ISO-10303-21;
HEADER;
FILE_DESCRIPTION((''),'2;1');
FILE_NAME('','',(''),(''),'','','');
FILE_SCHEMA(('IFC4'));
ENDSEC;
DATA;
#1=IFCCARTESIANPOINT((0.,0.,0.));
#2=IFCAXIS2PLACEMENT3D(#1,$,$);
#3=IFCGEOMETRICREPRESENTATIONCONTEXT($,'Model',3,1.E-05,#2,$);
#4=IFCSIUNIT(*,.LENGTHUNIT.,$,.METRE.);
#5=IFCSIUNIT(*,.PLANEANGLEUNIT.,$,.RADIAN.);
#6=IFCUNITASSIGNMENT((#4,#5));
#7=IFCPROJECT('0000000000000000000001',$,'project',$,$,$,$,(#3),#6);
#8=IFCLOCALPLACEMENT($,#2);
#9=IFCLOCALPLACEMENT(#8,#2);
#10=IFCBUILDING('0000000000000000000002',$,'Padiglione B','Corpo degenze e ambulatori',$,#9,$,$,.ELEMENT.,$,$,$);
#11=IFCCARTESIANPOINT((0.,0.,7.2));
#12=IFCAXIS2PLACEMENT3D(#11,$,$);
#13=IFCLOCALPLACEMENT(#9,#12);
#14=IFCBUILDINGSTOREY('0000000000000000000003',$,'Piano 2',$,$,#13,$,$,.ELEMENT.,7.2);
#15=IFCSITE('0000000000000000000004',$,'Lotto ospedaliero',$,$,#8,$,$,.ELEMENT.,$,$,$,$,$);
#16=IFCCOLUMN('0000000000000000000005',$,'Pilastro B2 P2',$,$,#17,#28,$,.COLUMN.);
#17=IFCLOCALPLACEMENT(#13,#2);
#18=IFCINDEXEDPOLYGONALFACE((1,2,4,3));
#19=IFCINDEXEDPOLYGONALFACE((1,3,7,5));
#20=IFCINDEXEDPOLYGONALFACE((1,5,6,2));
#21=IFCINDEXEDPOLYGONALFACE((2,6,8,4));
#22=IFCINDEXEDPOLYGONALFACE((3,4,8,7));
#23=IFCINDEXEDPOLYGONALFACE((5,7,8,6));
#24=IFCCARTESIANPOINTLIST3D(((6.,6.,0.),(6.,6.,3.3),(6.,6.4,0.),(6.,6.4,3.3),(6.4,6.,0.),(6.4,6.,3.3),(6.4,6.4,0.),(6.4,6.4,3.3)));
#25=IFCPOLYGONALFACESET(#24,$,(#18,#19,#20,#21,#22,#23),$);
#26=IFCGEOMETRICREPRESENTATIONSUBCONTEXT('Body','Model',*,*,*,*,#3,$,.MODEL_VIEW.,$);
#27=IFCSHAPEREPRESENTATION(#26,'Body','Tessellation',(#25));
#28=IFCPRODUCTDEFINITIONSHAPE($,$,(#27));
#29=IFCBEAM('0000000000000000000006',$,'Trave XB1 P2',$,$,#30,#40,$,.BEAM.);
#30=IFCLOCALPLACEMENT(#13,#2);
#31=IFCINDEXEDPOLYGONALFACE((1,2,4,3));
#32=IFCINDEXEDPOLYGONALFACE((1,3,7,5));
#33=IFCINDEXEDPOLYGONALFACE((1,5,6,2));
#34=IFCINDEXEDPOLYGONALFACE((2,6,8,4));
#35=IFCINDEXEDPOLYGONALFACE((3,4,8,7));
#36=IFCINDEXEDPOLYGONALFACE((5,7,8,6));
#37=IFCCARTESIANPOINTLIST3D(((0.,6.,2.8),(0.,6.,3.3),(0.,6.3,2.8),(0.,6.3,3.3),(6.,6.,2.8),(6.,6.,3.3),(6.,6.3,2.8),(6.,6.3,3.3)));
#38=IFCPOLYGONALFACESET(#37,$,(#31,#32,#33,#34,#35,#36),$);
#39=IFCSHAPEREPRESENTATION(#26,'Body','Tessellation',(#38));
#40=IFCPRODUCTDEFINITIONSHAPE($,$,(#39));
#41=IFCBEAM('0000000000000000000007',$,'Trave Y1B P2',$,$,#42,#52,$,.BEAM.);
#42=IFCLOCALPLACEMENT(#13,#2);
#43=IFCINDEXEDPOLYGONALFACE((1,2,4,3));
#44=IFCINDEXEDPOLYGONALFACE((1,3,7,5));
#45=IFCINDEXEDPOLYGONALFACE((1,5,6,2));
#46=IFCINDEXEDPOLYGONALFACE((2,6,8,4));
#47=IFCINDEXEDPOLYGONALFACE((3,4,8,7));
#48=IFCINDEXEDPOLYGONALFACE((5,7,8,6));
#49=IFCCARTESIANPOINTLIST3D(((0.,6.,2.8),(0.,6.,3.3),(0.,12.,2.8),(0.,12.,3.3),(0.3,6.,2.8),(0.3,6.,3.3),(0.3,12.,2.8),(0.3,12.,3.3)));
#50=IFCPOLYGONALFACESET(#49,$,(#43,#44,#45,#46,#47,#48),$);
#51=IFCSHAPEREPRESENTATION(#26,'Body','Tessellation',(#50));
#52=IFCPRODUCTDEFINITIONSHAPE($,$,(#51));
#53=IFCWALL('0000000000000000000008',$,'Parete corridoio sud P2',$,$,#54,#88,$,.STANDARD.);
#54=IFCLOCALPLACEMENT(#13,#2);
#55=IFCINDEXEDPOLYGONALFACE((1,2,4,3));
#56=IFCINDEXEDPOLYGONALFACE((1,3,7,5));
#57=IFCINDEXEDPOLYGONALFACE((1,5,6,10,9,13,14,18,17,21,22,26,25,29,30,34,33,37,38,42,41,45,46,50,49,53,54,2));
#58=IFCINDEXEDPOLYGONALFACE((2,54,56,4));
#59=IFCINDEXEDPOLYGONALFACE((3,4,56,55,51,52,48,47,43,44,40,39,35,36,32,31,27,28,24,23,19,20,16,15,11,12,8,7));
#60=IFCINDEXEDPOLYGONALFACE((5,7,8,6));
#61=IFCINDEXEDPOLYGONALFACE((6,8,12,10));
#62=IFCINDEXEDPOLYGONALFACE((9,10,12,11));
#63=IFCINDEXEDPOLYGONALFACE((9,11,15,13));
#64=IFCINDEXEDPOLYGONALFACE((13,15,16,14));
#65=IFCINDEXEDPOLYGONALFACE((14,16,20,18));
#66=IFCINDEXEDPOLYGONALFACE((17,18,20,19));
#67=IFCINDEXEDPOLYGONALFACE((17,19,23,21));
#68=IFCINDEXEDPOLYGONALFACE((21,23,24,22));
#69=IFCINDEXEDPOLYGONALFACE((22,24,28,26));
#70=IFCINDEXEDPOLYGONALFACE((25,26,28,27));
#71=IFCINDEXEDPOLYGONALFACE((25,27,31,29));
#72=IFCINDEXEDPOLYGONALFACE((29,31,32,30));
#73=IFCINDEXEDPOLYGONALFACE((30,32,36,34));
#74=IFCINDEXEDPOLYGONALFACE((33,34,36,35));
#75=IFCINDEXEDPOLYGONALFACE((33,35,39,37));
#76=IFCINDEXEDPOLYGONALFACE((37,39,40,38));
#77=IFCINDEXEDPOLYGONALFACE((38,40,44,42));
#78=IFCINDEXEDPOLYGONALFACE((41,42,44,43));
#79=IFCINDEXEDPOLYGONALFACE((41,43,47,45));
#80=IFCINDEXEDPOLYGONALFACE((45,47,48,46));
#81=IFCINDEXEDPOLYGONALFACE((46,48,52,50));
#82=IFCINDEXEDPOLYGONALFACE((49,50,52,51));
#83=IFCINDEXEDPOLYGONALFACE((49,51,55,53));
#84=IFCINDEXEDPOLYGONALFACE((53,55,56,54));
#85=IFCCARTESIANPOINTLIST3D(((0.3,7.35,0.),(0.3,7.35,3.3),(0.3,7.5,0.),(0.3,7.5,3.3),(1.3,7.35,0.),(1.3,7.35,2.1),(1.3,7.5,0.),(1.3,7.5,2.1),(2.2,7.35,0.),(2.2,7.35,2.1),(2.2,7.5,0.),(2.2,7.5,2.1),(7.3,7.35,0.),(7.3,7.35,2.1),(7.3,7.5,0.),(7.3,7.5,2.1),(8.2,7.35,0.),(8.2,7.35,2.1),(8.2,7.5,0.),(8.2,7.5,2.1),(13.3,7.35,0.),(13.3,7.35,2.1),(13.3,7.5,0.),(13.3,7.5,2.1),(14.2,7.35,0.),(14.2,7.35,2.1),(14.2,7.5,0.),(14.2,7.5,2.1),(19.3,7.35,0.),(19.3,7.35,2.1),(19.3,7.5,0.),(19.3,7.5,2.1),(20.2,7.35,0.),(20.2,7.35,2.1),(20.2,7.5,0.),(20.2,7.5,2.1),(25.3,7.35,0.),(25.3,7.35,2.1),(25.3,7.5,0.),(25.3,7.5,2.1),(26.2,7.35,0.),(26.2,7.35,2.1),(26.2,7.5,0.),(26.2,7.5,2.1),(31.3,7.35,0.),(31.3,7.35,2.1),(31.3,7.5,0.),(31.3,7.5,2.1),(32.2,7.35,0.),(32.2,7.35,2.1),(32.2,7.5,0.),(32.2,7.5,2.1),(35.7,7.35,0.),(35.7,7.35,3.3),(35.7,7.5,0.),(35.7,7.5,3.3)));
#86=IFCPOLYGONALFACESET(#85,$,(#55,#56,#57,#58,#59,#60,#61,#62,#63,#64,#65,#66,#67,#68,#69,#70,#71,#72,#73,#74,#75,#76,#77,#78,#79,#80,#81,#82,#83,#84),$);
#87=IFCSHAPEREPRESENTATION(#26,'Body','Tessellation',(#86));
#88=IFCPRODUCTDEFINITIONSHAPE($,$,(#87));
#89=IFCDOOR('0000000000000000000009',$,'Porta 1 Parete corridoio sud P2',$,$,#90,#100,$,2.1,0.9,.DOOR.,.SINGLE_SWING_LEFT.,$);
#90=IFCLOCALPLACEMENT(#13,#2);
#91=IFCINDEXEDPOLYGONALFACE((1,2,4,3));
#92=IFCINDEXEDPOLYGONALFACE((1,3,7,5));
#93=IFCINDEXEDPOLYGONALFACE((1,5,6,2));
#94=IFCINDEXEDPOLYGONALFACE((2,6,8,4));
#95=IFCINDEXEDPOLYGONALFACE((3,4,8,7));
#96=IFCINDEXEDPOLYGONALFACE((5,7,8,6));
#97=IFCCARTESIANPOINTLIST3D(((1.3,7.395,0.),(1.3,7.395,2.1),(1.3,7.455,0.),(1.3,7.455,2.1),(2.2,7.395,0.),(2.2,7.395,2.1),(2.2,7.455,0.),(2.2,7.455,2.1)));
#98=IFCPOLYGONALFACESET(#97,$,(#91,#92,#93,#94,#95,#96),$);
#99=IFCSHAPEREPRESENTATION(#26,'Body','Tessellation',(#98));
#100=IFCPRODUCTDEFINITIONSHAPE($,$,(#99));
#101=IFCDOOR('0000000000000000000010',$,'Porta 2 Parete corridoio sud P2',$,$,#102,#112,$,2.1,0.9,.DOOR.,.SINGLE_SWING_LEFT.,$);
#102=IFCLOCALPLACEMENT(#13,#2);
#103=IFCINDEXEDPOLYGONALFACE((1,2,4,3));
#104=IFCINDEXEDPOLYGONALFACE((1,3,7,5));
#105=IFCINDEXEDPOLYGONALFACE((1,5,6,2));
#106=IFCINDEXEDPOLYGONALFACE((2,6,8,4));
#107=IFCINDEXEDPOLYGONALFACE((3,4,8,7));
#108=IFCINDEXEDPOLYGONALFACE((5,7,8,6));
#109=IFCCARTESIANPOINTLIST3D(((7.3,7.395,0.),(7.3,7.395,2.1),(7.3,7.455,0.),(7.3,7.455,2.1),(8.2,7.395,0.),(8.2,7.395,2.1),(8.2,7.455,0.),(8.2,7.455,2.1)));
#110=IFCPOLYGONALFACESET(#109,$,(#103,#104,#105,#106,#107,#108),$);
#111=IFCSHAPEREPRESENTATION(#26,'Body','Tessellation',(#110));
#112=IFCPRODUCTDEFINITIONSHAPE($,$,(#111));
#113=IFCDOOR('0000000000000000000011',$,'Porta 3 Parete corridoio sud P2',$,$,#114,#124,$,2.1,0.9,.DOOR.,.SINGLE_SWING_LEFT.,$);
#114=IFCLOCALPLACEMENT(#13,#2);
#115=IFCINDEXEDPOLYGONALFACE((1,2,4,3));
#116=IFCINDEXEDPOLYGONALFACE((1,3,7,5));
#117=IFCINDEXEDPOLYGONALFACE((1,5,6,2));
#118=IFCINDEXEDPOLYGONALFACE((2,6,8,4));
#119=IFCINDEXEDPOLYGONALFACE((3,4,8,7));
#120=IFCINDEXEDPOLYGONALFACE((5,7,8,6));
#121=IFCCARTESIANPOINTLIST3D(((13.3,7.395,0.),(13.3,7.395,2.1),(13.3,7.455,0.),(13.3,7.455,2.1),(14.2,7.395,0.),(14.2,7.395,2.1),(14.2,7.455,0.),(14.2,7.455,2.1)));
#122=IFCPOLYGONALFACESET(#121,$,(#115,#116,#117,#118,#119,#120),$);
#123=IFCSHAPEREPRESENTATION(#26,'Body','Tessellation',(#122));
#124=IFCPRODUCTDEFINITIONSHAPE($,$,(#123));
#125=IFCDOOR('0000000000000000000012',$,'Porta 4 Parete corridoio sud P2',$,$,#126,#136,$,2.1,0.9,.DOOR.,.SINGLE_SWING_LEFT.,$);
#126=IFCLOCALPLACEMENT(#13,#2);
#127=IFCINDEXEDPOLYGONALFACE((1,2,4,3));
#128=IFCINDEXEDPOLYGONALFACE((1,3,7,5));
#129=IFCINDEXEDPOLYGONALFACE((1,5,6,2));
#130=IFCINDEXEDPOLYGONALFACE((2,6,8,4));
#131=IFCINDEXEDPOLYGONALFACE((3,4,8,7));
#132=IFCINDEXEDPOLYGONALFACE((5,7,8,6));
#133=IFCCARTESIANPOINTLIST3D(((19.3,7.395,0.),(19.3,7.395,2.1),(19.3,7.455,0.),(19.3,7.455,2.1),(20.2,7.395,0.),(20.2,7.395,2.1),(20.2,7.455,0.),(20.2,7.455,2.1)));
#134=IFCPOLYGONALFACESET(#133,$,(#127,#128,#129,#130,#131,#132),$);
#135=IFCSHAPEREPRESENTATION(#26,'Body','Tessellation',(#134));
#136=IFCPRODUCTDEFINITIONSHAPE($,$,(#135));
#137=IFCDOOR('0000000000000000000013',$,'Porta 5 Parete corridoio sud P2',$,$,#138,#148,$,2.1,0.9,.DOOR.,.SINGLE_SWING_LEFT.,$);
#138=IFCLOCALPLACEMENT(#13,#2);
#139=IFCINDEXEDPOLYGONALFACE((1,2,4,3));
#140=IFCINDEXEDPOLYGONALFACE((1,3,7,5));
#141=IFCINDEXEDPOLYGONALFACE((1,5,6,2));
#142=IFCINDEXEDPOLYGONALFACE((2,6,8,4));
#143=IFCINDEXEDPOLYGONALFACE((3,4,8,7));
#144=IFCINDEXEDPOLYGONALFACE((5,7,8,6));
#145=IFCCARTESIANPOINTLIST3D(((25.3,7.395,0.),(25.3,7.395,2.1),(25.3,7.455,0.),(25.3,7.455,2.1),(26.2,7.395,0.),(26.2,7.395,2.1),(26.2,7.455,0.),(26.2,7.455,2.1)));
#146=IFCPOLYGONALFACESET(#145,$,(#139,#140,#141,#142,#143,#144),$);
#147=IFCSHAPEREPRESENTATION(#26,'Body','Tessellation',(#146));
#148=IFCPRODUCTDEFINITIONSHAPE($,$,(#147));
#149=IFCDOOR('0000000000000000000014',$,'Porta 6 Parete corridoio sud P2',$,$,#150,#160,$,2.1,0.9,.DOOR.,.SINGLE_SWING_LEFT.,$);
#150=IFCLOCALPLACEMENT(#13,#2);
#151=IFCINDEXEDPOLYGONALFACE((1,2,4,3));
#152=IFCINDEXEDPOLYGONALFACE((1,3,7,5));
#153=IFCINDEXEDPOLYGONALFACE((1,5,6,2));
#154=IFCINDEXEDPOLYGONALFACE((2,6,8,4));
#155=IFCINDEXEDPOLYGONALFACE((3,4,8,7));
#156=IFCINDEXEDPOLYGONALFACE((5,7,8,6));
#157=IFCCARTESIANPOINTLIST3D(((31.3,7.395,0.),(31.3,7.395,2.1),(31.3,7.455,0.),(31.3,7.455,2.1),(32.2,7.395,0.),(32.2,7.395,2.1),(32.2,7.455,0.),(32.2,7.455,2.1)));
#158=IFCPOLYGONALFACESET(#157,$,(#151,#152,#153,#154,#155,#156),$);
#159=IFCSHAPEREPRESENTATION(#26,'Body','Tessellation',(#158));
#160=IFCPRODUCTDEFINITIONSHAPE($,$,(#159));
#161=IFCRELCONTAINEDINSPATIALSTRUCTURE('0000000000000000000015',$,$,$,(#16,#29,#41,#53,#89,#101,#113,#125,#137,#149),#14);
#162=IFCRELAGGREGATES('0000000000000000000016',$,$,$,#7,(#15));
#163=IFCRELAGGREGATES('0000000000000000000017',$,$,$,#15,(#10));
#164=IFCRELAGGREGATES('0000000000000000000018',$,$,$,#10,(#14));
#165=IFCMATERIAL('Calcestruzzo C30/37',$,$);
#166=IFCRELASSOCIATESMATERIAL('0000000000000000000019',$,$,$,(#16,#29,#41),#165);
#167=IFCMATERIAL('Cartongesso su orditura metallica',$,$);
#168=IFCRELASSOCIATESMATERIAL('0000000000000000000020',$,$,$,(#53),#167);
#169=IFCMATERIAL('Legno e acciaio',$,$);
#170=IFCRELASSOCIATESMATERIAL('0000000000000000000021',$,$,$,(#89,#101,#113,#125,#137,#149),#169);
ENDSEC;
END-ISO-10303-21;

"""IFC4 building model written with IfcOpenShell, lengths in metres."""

from ifc_helpers import new_model, si_unit, frame, frame_2d, origin, place, context, subcontext, project, spatial, rectangle, extrude, material, element, fill, save


model = new_model("IFC4")

# Units and contexts
model_context = context("Model", 3, precision=1e-05, world=origin())
body_context = subcontext(model_context, "Body", "Model", "MODEL_VIEW")
ifc_project = project(units=[si_unit("LENGTHUNIT", "METRE"), si_unit("PLANEANGLEUNIT", "RADIAN")], contexts=[model_context])

# Site, building, storey
site_placement = place(None, origin())
site = spatial("IfcSite", under=ifc_project, at=site_placement, Name="Lotto ospedaliero", CompositionType="ELEMENT")
building_placement = place(site_placement, origin())
building = spatial("IfcBuilding", under=site, at=building_placement, Name="Padiglione B", Description="Corpo degenze e ambulatori", CompositionType="ELEMENT")
storey_placement = place(building_placement, frame((0.0, 0.0, 7.2)))
storey = spatial("IfcBuildingStorey", under=building, at=storey_placement, Name="Piano 2", CompositionType="ELEMENT", Elevation=7.2)

# Column
ifc_material_1 = material(Name="Calcestruzzo C30/37")
column_placement = place(storey_placement, frame((6.0, 6.0, 0.0)))
element("IfcColumn", 1, at=column_placement, inside=storey, material=ifc_material_1, Name="Pilastro B2 P2", PredefinedType="COLUMN", context=body_context, shape_type="SweptSolid", body=[
    extrude(rectangle(XDim=0.4, YDim=0.4, at=frame_2d((0.2, 0.2))), origin(), (0.0, 0.0, 1.0), 3.3),
])

# Beams
beam_1_placement = place(storey_placement, frame((0.0, 6.0, 2.8)))
element("IfcBeam", 2, at=beam_1_placement, inside=storey, material=ifc_material_1, Name="Trave XB1 P2", PredefinedType="BEAM", context=body_context, shape_type="SweptSolid", body=[
    extrude(rectangle(XDim=6.0, YDim=0.3, at=frame_2d((3.0, 0.15))), origin(), (0.0, 0.0, 1.0), 0.5),
])
beam_2_placement = place(storey_placement, frame((0.0, 6.0, 2.8)))
element("IfcBeam", 3, at=beam_2_placement, inside=storey, material=ifc_material_1, Name="Trave Y1B P2", PredefinedType="BEAM", context=body_context, shape_type="SweptSolid", body=[
    extrude(rectangle(XDim=0.3, YDim=6.0, at=frame_2d((0.15, 3.0))), origin(), (0.0, 0.0, 1.0), 0.5),
])

# Wall, openings, doors
ifc_material_2 = material(Name="Cartongesso su orditura metallica")
wall_1_placement = place(storey_placement, frame((0.3, 7.35, 0.0)))
wall_1 = element("IfcWall", 4, at=wall_1_placement, inside=storey, material=ifc_material_2, Name="Parete corridoio sud P2", PredefinedType="STANDARD", context=body_context, shape_type="SweptSolid", body=[
    extrude(rectangle(XDim=35.4, YDim=0.15, at=frame_2d((17.7, 0.075))), origin(), (0.0, 0.0, 1.0), 3.3),
])
opening_1_placement = place(wall_1_placement, frame((1.0, -0.1, 0.0)))
opening_1 = element("IfcOpeningElement", 5, at=opening_1_placement, cuts=wall_1, PredefinedType="OPENING", context=body_context, shape_type="SweptSolid", body=[
    extrude(rectangle(XDim=0.9, YDim=0.35, at=frame_2d((0.45, 0.175))), origin(), (0.0, 0.0, 1.0), 2.1),
])
opening_2_placement = place(wall_1_placement, frame((7.0, -0.1, 0.0)))
opening_2 = element("IfcOpeningElement", 6, at=opening_2_placement, cuts=wall_1, PredefinedType="OPENING", context=body_context, shape_type="SweptSolid", body=[
    extrude(rectangle(XDim=0.9, YDim=0.35, at=frame_2d((0.45, 0.175))), origin(), (0.0, 0.0, 1.0), 2.1),
])
opening_3_placement = place(wall_1_placement, frame((13.0, -0.1, 0.0)))
opening_3 = element("IfcOpeningElement", 7, at=opening_3_placement, cuts=wall_1, PredefinedType="OPENING", context=body_context, shape_type="SweptSolid", body=[
    extrude(rectangle(XDim=0.9, YDim=0.35, at=frame_2d((0.45, 0.175))), origin(), (0.0, 0.0, 1.0), 2.1),
])
opening_4_placement = place(wall_1_placement, frame((19.0, -0.1, 0.0)))
opening_4 = element("IfcOpeningElement", 8, at=opening_4_placement, cuts=wall_1, PredefinedType="OPENING", context=body_context, shape_type="SweptSolid", body=[
    extrude(rectangle(XDim=0.9, YDim=0.35, at=frame_2d((0.45, 0.175))), origin(), (0.0, 0.0, 1.0), 2.1),
])
opening_5_placement = place(wall_1_placement, frame((25.0, -0.1, 0.0)))
opening_5 = element("IfcOpeningElement", 9, at=opening_5_placement, cuts=wall_1, PredefinedType="OPENING", context=body_context, shape_type="SweptSolid", body=[
    extrude(rectangle(XDim=0.9, YDim=0.35, at=frame_2d((0.45, 0.175))), origin(), (0.0, 0.0, 1.0), 2.1),
])
opening_6_placement = place(wall_1_placement, frame((31.0, -0.1, 0.0)))
opening_6 = element("IfcOpeningElement", 10, at=opening_6_placement, cuts=wall_1, PredefinedType="OPENING", context=body_context, shape_type="SweptSolid", body=[
    extrude(rectangle(XDim=0.9, YDim=0.35, at=frame_2d((0.45, 0.175))), origin(), (0.0, 0.0, 1.0), 2.1),
])
ifc_material_3 = material(Name="Legno e acciaio")
door_1_placement = place(wall_1_placement, frame((1.0, 0.045, 0.0)))
door_1 = element("IfcDoor", 11, at=door_1_placement, inside=storey, material=ifc_material_3, Name="Porta 1 Parete corridoio sud P2", OperationType="SINGLE_SWING_LEFT", OverallHeight=2.1, OverallWidth=0.9, PredefinedType="DOOR", context=body_context, shape_type="SweptSolid", body=[
    extrude(rectangle(XDim=0.9, YDim=0.06, at=frame_2d((0.45, 0.03))), origin(), (0.0, 0.0, 1.0), 2.1),
])
fill(opening_1, door_1)
door_2_placement = place(wall_1_placement, frame((7.0, 0.045, 0.0)))
door_2 = element("IfcDoor", 12, at=door_2_placement, inside=storey, material=ifc_material_3, Name="Porta 2 Parete corridoio sud P2", OperationType="SINGLE_SWING_LEFT", OverallHeight=2.1, OverallWidth=0.9, PredefinedType="DOOR", context=body_context, shape_type="SweptSolid", body=[
    extrude(rectangle(XDim=0.9, YDim=0.06, at=frame_2d((0.45, 0.03))), origin(), (0.0, 0.0, 1.0), 2.1),
])
fill(opening_2, door_2)
door_3_placement = place(wall_1_placement, frame((13.0, 0.045, 0.0)))
door_3 = element("IfcDoor", 13, at=door_3_placement, inside=storey, material=ifc_material_3, Name="Porta 3 Parete corridoio sud P2", OperationType="SINGLE_SWING_LEFT", OverallHeight=2.1, OverallWidth=0.9, PredefinedType="DOOR", context=body_context, shape_type="SweptSolid", body=[
    extrude(rectangle(XDim=0.9, YDim=0.06, at=frame_2d((0.45, 0.03))), origin(), (0.0, 0.0, 1.0), 2.1),
])
fill(opening_3, door_3)
door_4_placement = place(wall_1_placement, frame((19.0, 0.045, 0.0)))
door_4 = element("IfcDoor", 14, at=door_4_placement, inside=storey, material=ifc_material_3, Name="Porta 4 Parete corridoio sud P2", OperationType="SINGLE_SWING_LEFT", OverallHeight=2.1, OverallWidth=0.9, PredefinedType="DOOR", context=body_context, shape_type="SweptSolid", body=[
    extrude(rectangle(XDim=0.9, YDim=0.06, at=frame_2d((0.45, 0.03))), origin(), (0.0, 0.0, 1.0), 2.1),
])
fill(opening_4, door_4)
door_5_placement = place(wall_1_placement, frame((25.0, 0.045, 0.0)))
door_5 = element("IfcDoor", 15, at=door_5_placement, inside=storey, material=ifc_material_3, Name="Porta 5 Parete corridoio sud P2", OperationType="SINGLE_SWING_LEFT", OverallHeight=2.1, OverallWidth=0.9, PredefinedType="DOOR", context=body_context, shape_type="SweptSolid", body=[
    extrude(rectangle(XDim=0.9, YDim=0.06, at=frame_2d((0.45, 0.03))), origin(), (0.0, 0.0, 1.0), 2.1),
])
fill(opening_5, door_5)
door_6_placement = place(wall_1_placement, frame((31.0, 0.045, 0.0)))
door_6 = element("IfcDoor", 16, at=door_6_placement, inside=storey, material=ifc_material_3, Name="Porta 6 Parete corridoio sud P2", OperationType="SINGLE_SWING_LEFT", OverallHeight=2.1, OverallWidth=0.9, PredefinedType="DOOR", context=body_context, shape_type="SweptSolid", body=[
    extrude(rectangle(XDim=0.9, YDim=0.06, at=frame_2d((0.45, 0.03))), origin(), (0.0, 0.0, 1.0), 2.1),
])
fill(opening_6, door_6)

save(model, "model.ifc")
